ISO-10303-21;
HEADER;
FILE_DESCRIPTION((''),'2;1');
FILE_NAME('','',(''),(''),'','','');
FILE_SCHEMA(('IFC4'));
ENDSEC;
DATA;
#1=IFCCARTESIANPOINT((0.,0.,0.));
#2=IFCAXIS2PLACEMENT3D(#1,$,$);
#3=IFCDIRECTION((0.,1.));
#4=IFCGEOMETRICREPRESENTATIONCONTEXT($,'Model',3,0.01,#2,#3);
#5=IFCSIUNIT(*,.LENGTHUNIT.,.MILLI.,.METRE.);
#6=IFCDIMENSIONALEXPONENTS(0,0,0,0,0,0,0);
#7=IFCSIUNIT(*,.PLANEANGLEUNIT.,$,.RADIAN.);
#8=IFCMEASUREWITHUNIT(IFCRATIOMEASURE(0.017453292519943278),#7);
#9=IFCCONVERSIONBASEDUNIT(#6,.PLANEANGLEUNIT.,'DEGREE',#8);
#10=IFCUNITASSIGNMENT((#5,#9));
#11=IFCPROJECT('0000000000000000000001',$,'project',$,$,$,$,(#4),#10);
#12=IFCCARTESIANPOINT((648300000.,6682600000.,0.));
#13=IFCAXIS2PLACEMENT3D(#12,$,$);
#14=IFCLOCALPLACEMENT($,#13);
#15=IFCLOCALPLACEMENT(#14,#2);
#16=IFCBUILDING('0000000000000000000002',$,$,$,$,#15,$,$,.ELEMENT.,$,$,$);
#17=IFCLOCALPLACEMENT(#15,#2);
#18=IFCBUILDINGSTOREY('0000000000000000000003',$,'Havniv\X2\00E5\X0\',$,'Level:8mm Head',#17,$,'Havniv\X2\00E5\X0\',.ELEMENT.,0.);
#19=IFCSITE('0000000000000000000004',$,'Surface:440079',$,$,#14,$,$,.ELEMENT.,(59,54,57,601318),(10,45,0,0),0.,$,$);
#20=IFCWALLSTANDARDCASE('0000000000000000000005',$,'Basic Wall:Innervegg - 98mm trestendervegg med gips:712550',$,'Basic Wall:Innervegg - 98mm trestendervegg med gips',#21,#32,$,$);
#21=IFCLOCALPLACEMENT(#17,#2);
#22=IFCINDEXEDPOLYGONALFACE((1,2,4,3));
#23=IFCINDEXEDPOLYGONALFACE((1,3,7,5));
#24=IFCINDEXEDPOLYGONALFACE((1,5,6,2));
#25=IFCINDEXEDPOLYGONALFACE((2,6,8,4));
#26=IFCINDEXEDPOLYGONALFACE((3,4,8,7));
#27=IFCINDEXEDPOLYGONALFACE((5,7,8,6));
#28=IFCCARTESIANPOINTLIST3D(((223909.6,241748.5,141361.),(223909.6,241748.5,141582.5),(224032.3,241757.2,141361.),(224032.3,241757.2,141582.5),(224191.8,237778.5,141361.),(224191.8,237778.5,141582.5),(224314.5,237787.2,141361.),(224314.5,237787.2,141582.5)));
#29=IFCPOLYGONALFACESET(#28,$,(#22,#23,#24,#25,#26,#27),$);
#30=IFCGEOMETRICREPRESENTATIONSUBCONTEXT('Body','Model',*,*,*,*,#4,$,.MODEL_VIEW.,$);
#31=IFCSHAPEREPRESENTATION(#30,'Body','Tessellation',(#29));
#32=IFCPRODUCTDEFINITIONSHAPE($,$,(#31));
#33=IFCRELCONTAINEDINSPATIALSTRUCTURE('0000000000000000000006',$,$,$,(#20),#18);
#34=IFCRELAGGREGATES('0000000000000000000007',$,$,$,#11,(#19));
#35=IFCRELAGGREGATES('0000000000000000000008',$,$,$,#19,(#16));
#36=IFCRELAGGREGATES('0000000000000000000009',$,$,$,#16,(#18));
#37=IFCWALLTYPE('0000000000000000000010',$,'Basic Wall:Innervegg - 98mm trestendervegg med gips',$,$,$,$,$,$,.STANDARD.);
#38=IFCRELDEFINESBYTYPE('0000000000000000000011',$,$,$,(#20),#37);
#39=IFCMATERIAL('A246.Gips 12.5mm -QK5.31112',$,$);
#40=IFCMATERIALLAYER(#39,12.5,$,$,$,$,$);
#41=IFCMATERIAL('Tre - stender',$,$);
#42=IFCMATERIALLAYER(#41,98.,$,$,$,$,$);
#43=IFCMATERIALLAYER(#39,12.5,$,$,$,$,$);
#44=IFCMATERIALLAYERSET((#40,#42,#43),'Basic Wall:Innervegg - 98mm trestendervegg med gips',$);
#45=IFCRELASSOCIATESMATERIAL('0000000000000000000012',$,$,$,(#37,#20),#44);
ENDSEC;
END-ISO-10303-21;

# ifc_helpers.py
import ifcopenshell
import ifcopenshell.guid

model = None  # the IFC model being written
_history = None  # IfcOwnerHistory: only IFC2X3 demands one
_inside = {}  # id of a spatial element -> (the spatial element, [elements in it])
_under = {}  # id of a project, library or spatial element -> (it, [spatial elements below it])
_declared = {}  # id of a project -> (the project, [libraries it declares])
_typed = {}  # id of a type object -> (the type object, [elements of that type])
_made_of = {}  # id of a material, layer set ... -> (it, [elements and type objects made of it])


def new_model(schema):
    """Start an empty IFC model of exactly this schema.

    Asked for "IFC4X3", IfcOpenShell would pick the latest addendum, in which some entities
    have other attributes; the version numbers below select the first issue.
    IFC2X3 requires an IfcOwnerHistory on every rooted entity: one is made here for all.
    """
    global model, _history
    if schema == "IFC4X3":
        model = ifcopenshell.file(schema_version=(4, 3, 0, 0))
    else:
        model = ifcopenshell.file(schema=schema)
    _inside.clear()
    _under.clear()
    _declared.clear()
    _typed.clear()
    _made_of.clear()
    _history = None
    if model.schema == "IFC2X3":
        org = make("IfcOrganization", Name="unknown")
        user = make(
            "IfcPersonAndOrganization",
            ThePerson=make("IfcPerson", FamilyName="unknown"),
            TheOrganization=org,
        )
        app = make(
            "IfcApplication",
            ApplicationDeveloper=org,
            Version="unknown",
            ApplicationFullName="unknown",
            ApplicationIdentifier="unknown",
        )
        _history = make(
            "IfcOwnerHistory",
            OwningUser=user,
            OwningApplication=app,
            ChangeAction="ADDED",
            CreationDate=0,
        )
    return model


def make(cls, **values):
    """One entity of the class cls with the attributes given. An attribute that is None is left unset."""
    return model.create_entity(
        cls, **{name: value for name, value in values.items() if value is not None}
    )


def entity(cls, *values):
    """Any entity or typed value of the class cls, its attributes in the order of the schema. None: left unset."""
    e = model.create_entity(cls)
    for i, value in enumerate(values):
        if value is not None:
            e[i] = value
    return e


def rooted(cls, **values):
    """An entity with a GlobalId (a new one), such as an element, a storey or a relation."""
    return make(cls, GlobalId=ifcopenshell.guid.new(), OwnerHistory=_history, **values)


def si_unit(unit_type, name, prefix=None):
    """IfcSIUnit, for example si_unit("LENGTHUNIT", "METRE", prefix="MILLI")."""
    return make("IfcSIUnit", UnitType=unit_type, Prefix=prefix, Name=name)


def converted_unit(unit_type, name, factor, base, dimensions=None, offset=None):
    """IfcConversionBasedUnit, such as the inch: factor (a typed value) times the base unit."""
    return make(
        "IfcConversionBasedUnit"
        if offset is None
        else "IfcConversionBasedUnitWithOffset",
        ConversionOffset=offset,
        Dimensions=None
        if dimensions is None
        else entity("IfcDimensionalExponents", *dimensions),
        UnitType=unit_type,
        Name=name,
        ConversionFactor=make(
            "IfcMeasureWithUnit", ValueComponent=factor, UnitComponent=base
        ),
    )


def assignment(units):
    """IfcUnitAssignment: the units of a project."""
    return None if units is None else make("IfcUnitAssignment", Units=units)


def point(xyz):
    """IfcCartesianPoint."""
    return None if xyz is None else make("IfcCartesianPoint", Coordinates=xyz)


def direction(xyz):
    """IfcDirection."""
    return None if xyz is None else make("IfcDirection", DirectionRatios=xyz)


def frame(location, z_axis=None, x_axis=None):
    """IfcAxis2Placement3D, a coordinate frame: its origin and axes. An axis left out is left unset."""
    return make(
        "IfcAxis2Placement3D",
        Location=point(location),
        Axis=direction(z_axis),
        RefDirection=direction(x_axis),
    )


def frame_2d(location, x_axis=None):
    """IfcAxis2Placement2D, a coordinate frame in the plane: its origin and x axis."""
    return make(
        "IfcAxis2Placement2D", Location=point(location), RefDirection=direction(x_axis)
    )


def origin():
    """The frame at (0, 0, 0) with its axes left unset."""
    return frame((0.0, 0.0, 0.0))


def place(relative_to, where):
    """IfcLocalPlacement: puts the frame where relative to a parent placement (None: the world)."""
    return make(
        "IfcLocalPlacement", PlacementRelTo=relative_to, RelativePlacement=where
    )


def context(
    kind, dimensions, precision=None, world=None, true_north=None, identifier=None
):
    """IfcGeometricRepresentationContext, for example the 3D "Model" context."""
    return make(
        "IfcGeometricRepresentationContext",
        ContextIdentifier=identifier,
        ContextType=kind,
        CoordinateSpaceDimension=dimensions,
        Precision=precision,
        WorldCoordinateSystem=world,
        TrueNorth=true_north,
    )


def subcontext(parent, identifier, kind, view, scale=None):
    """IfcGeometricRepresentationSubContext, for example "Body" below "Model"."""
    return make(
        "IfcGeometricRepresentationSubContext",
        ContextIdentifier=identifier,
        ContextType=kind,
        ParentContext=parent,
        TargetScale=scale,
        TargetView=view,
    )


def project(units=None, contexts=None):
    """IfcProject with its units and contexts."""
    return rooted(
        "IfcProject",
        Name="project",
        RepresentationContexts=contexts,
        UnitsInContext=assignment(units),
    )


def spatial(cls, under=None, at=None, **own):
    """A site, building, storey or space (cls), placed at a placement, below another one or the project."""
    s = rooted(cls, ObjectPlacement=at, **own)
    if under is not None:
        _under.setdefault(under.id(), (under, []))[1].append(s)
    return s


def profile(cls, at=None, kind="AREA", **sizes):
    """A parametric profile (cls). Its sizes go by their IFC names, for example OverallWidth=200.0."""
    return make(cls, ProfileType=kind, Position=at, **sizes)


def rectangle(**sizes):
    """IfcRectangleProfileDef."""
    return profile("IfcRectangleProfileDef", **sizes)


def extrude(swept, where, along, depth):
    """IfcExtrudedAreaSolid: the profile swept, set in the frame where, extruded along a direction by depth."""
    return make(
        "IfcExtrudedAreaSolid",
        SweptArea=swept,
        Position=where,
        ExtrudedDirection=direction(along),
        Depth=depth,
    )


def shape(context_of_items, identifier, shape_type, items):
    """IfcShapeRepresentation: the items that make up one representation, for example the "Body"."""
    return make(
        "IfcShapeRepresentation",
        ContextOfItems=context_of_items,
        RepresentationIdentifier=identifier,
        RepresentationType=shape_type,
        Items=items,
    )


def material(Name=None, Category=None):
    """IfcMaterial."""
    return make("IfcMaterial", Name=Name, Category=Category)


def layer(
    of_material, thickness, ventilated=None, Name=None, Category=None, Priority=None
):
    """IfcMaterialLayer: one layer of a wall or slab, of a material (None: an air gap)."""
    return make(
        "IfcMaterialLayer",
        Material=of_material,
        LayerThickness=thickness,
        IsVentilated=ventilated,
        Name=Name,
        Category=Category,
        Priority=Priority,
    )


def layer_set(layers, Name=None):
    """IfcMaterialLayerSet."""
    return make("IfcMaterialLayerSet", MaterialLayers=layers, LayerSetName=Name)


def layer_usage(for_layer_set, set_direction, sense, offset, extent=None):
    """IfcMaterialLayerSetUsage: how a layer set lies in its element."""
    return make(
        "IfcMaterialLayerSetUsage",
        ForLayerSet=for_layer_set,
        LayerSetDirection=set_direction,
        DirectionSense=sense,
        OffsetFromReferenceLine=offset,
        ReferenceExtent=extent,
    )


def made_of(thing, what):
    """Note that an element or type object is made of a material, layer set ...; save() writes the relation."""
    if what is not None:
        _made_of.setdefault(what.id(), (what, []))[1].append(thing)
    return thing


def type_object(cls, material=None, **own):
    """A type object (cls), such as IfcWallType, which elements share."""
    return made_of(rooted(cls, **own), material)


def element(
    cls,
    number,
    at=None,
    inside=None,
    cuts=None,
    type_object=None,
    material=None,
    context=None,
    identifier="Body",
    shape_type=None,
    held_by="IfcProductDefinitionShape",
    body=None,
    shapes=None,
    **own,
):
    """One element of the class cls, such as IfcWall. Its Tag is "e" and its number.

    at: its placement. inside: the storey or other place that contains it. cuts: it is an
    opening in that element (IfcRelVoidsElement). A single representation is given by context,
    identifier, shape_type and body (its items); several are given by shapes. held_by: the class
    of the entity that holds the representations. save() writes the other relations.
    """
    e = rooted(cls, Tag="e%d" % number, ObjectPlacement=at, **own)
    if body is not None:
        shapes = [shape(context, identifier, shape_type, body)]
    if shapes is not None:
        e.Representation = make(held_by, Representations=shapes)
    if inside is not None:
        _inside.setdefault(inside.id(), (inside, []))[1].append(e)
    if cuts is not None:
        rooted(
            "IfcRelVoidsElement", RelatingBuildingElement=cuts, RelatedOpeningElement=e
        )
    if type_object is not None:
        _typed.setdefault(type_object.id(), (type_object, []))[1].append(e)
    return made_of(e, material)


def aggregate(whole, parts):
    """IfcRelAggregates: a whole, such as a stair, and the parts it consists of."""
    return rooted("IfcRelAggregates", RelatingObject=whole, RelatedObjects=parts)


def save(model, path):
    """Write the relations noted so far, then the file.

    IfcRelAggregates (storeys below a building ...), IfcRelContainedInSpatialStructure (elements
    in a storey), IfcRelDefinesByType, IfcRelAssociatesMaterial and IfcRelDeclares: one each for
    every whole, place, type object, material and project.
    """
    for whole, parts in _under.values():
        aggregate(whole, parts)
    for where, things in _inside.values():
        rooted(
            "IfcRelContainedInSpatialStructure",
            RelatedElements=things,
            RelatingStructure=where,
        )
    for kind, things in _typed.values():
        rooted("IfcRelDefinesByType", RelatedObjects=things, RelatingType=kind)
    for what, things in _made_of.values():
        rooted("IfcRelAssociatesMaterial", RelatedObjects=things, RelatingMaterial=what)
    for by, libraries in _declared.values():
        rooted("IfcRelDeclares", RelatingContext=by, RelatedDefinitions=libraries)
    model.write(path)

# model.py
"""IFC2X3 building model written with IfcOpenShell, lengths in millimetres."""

from ifc_helpers import new_model, entity, si_unit, converted_unit, direction, frame, frame_2d, origin, place, context, subcontext, project, spatial, rectangle, extrude, material, layer, layer_set, layer_usage, type_object, element, save


model = new_model("IFC2X3")

# Units and contexts
model_context = context("Model", 3, precision=0.01, world=origin(), true_north=direction((0.0, 1.0)))
body_context = subcontext(model_context, "Body", "Model", "MODEL_VIEW")
ifc_project = project(units=[si_unit("LENGTHUNIT", "METRE", prefix="MILLI"), converted_unit("PLANEANGLEUNIT", "DEGREE", entity("IfcRatioMeasure", 0.017453292519943278), si_unit("PLANEANGLEUNIT", "RADIAN"), dimensions=[0, 0, 0, 0, 0, 0, 0])], contexts=[model_context])

# Site, building, storey
site_placement = place(None, frame((648300000.0, 6682600000.0, 0.0)))
site = spatial("IfcSite", under=ifc_project, at=site_placement, Name="Surface:440079", CompositionType="ELEMENT", RefLatitude=(59, 54, 57, 601318), RefLongitude=(10, 45, 0, 0), RefElevation=0.0)
building_placement = place(site_placement, origin())
building = spatial("IfcBuilding", under=site, at=building_placement, CompositionType="ELEMENT")
storey_placement = place(building_placement, origin())
storey = spatial("IfcBuildingStorey", under=building, at=storey_placement, Name="Havnivå", ObjectType="Level:8mm Head", LongName="Havnivå", CompositionType="ELEMENT", Elevation=0.0)

# Wall
ifc_material_1 = material(Name="A246.Gips 12.5mm -QK5.31112")
ifc_layer_1 = layer(ifc_material_1, 12.5)
ifc_material_2 = material(Name="Tre - stender")
ifc_layer_2 = layer(ifc_material_2, 98.0)
ifc_layer_3 = layer(ifc_material_1, 12.5)
ifc_layer_set = layer_set([ifc_layer_1, ifc_layer_2, ifc_layer_3], Name="Basic Wall:Innervegg - 98mm trestendervegg med gips")
ifc_layer_usage = layer_usage(ifc_layer_set, "AXIS2", "NEGATIVE", 61.5)
wall_type = type_object("IfcWallType", Name="Basic Wall:Innervegg - 98mm trestendervegg med gips", PredefinedType="STANDARD", material=ifc_layer_set)
wall_placement = place(storey_placement, frame((224253.2, 237782.9, 141361.0), z_axis=(0.0, 0.0, 1.0), x_axis=(-0.070908, 0.997483, 0.0)))
element("IfcWallStandardCase", 1, at=wall_placement, inside=storey, type_object=wall_type, material=ifc_layer_usage, Name="Basic Wall:Innervegg - 98mm trestendervegg med gips:712550", ObjectType="Basic Wall:Innervegg - 98mm trestendervegg med gips", context=body_context, shape_type="SweptSolid", body=[
    extrude(rectangle(XDim=3980.0, YDim=123.0, at=frame_2d((1990.0, 0.0), x_axis=(-1.0, 0.0))), origin(), (0.0, 0.0, 1.0), 221.5),
])

save(model, "model.ifc")
